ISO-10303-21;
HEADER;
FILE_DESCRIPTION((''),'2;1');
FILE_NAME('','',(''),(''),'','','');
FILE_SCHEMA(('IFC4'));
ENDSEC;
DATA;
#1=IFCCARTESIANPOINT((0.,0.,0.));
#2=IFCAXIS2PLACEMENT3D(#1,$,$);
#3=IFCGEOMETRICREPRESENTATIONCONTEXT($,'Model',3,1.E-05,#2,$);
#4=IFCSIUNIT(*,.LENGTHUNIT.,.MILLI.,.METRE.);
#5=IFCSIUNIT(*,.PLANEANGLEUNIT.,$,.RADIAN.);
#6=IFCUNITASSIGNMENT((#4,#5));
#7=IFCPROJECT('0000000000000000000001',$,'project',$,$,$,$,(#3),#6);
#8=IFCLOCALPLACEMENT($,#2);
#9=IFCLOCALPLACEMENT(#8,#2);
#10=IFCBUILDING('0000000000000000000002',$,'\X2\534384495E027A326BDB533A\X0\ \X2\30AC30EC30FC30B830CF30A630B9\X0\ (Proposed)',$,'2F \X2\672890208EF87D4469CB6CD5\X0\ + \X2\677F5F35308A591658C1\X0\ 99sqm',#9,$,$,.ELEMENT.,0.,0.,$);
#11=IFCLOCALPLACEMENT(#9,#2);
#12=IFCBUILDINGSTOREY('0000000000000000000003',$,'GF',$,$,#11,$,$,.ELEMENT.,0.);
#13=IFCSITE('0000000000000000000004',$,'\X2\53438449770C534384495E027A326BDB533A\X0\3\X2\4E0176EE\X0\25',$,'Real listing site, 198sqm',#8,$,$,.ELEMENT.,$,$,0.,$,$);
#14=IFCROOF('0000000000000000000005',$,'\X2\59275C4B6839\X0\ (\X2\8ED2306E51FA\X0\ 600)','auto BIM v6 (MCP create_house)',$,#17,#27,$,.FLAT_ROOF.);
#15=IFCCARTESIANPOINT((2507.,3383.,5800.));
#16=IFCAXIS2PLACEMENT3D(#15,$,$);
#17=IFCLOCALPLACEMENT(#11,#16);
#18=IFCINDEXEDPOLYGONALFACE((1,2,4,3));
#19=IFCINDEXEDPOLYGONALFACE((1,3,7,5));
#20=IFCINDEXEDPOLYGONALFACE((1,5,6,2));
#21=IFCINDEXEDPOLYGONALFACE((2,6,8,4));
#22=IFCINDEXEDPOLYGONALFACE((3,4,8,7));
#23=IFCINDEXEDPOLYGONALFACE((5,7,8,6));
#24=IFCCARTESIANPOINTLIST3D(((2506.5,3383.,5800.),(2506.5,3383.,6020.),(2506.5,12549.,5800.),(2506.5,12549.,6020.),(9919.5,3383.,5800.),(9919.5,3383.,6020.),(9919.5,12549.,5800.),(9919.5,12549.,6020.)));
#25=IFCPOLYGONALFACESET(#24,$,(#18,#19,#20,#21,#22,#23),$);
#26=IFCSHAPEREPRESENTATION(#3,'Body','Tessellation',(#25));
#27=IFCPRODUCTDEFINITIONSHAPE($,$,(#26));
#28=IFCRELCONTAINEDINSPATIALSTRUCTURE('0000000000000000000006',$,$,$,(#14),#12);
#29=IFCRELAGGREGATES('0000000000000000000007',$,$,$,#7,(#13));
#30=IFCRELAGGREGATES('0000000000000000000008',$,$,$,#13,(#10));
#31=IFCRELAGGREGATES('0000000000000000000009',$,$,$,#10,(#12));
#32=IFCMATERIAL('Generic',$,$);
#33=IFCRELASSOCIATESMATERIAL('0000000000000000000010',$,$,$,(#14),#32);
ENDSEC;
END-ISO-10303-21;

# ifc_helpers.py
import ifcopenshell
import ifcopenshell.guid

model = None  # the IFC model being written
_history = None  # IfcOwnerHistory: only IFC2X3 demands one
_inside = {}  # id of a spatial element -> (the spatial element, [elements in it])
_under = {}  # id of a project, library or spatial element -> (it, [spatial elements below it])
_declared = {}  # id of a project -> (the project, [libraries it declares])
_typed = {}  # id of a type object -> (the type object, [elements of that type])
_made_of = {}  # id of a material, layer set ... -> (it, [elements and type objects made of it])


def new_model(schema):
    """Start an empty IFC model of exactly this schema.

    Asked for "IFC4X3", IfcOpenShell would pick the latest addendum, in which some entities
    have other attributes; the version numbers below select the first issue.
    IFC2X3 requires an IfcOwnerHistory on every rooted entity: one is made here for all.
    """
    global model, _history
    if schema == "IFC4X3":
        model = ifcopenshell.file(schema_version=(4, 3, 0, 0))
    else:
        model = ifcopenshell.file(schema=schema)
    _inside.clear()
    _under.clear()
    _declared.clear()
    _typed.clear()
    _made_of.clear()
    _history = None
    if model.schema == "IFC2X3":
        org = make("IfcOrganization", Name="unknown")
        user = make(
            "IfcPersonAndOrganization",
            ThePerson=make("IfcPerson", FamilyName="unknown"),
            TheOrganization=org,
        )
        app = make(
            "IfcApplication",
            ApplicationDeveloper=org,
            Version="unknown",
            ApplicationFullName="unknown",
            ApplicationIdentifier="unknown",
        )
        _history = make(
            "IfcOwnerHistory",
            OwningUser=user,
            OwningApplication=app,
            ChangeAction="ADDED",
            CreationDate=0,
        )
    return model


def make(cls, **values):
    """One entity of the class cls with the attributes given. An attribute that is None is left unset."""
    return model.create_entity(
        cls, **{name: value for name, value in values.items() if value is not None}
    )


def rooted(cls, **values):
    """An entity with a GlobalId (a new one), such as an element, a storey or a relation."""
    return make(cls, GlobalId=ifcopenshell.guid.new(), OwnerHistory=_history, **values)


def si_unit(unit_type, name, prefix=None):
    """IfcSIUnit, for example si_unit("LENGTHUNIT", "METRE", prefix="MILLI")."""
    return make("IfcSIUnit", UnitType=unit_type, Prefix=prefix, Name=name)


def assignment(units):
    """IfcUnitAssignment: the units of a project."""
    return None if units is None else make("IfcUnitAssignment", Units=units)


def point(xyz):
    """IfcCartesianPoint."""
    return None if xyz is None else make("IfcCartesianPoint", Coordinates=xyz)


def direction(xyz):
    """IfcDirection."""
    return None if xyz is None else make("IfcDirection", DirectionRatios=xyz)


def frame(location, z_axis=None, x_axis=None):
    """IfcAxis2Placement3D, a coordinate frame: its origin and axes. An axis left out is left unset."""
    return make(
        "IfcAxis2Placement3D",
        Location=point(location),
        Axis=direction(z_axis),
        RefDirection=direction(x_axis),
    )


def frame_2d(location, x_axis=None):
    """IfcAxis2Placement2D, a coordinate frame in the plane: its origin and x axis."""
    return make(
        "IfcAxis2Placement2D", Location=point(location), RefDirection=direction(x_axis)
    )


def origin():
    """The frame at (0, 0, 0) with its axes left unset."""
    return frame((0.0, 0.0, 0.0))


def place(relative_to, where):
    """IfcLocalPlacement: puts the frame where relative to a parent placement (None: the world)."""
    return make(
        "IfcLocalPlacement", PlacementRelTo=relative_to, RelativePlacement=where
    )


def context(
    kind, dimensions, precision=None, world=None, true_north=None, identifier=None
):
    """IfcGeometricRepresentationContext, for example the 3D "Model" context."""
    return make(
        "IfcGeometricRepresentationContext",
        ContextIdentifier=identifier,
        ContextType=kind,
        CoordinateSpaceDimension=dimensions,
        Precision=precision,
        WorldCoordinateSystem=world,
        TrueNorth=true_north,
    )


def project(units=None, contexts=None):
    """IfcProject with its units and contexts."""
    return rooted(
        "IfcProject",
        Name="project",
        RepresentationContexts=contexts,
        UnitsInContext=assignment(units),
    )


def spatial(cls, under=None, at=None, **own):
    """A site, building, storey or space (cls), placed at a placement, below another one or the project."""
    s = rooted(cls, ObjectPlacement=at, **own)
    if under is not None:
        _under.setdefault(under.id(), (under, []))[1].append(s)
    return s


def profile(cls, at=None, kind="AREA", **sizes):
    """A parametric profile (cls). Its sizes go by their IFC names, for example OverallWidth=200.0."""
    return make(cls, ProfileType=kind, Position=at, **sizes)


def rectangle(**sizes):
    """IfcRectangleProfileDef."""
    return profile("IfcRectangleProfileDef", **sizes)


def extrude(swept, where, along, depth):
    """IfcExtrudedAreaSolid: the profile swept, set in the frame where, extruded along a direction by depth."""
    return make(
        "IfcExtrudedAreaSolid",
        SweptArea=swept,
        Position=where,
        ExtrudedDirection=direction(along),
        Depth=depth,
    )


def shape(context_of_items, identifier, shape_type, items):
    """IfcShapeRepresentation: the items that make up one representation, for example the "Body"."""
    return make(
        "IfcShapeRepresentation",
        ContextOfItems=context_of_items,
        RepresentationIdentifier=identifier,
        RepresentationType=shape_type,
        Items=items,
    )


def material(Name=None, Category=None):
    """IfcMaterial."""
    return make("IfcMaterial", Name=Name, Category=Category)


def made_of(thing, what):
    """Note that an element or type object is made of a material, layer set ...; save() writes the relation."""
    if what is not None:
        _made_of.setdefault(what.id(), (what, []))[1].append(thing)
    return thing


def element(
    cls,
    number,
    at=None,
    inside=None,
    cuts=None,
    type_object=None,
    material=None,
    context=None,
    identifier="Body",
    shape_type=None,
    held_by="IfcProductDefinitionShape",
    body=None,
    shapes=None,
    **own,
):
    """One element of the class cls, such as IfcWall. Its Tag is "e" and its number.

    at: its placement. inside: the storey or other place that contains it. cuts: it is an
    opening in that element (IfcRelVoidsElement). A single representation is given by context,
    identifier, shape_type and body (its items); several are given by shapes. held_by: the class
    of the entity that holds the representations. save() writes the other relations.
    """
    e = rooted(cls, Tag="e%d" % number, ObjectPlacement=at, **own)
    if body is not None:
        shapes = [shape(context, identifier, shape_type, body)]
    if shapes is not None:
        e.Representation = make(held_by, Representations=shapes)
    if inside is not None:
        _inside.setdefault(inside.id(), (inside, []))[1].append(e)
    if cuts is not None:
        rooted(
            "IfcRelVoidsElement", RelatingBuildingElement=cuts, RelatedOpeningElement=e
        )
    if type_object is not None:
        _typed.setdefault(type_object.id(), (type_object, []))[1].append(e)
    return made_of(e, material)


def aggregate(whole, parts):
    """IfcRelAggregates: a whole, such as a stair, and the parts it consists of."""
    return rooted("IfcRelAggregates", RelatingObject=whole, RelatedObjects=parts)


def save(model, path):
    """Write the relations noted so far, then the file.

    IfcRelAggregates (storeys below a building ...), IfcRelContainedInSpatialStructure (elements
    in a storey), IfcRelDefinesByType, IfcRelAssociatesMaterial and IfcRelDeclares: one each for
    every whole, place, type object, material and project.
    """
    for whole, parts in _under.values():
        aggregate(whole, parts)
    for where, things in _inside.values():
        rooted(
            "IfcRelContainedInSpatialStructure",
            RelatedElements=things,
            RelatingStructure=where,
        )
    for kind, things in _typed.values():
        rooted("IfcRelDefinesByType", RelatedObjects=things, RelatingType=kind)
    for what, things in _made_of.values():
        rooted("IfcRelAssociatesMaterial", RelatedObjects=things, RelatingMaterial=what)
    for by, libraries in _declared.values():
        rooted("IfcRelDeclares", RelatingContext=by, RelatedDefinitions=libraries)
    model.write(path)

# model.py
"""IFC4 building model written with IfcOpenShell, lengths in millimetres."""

from ifc_helpers import new_model, si_unit, frame, frame_2d, origin, place, context, project, spatial, rectangle, extrude, material, element, save


model = new_model("IFC4")

# Units and contexts
model_context = context("Model", 3, precision=1e-05, world=origin())
ifc_project = project(units=[si_unit("LENGTHUNIT", "METRE", prefix="MILLI"), si_unit("PLANEANGLEUNIT", "RADIAN")], contexts=[model_context])

# Site, building, storey
site_placement = place(None, origin())
site = spatial("IfcSite", under=ifc_project, at=site_placement, Name="千葉県千葉市稲毛区3丁目25", ObjectType="Real listing site, 198sqm", CompositionType="ELEMENT", RefElevation=0.0)
building_placement = place(site_placement, origin())
building = spatial("IfcBuilding", under=site, at=building_placement, Name="千葉市稲毛区 ガレージハウス (Proposed)", ObjectType="2F 木造軸組構法 + 板張り外壁 99sqm", CompositionType="ELEMENT", ElevationOfRefHeight=0.0, ElevationOfTerrain=0.0)
storey_placement = place(building_placement, origin())
storey = spatial("IfcBuildingStorey", under=building, at=storey_placement, Name="GF", CompositionType="ELEMENT", Elevation=0.0)

# Shared definitions
ifc_material = material(Name="Generic")

# Roof
roof_placement = place(storey_placement, frame((2507.0, 3383.0, 5800.0)))
element("IfcRoof", 1, at=roof_placement, inside=storey, material=ifc_material, Name="大屋根 (軒の出 600)", Description="auto BIM v6 (MCP create_house)", PredefinedType="FLAT_ROOF", context=model_context, shape_type="SweptSolid", body=[
    extrude(rectangle(XDim=7413.0, YDim=9166.0, at=frame_2d((3706.0, 4583.0))), frame((2507.0, 3383.0, 5800.0)), (0.0, 0.0, 1.0), 220.0),
])

save(model, "model.ifc")
